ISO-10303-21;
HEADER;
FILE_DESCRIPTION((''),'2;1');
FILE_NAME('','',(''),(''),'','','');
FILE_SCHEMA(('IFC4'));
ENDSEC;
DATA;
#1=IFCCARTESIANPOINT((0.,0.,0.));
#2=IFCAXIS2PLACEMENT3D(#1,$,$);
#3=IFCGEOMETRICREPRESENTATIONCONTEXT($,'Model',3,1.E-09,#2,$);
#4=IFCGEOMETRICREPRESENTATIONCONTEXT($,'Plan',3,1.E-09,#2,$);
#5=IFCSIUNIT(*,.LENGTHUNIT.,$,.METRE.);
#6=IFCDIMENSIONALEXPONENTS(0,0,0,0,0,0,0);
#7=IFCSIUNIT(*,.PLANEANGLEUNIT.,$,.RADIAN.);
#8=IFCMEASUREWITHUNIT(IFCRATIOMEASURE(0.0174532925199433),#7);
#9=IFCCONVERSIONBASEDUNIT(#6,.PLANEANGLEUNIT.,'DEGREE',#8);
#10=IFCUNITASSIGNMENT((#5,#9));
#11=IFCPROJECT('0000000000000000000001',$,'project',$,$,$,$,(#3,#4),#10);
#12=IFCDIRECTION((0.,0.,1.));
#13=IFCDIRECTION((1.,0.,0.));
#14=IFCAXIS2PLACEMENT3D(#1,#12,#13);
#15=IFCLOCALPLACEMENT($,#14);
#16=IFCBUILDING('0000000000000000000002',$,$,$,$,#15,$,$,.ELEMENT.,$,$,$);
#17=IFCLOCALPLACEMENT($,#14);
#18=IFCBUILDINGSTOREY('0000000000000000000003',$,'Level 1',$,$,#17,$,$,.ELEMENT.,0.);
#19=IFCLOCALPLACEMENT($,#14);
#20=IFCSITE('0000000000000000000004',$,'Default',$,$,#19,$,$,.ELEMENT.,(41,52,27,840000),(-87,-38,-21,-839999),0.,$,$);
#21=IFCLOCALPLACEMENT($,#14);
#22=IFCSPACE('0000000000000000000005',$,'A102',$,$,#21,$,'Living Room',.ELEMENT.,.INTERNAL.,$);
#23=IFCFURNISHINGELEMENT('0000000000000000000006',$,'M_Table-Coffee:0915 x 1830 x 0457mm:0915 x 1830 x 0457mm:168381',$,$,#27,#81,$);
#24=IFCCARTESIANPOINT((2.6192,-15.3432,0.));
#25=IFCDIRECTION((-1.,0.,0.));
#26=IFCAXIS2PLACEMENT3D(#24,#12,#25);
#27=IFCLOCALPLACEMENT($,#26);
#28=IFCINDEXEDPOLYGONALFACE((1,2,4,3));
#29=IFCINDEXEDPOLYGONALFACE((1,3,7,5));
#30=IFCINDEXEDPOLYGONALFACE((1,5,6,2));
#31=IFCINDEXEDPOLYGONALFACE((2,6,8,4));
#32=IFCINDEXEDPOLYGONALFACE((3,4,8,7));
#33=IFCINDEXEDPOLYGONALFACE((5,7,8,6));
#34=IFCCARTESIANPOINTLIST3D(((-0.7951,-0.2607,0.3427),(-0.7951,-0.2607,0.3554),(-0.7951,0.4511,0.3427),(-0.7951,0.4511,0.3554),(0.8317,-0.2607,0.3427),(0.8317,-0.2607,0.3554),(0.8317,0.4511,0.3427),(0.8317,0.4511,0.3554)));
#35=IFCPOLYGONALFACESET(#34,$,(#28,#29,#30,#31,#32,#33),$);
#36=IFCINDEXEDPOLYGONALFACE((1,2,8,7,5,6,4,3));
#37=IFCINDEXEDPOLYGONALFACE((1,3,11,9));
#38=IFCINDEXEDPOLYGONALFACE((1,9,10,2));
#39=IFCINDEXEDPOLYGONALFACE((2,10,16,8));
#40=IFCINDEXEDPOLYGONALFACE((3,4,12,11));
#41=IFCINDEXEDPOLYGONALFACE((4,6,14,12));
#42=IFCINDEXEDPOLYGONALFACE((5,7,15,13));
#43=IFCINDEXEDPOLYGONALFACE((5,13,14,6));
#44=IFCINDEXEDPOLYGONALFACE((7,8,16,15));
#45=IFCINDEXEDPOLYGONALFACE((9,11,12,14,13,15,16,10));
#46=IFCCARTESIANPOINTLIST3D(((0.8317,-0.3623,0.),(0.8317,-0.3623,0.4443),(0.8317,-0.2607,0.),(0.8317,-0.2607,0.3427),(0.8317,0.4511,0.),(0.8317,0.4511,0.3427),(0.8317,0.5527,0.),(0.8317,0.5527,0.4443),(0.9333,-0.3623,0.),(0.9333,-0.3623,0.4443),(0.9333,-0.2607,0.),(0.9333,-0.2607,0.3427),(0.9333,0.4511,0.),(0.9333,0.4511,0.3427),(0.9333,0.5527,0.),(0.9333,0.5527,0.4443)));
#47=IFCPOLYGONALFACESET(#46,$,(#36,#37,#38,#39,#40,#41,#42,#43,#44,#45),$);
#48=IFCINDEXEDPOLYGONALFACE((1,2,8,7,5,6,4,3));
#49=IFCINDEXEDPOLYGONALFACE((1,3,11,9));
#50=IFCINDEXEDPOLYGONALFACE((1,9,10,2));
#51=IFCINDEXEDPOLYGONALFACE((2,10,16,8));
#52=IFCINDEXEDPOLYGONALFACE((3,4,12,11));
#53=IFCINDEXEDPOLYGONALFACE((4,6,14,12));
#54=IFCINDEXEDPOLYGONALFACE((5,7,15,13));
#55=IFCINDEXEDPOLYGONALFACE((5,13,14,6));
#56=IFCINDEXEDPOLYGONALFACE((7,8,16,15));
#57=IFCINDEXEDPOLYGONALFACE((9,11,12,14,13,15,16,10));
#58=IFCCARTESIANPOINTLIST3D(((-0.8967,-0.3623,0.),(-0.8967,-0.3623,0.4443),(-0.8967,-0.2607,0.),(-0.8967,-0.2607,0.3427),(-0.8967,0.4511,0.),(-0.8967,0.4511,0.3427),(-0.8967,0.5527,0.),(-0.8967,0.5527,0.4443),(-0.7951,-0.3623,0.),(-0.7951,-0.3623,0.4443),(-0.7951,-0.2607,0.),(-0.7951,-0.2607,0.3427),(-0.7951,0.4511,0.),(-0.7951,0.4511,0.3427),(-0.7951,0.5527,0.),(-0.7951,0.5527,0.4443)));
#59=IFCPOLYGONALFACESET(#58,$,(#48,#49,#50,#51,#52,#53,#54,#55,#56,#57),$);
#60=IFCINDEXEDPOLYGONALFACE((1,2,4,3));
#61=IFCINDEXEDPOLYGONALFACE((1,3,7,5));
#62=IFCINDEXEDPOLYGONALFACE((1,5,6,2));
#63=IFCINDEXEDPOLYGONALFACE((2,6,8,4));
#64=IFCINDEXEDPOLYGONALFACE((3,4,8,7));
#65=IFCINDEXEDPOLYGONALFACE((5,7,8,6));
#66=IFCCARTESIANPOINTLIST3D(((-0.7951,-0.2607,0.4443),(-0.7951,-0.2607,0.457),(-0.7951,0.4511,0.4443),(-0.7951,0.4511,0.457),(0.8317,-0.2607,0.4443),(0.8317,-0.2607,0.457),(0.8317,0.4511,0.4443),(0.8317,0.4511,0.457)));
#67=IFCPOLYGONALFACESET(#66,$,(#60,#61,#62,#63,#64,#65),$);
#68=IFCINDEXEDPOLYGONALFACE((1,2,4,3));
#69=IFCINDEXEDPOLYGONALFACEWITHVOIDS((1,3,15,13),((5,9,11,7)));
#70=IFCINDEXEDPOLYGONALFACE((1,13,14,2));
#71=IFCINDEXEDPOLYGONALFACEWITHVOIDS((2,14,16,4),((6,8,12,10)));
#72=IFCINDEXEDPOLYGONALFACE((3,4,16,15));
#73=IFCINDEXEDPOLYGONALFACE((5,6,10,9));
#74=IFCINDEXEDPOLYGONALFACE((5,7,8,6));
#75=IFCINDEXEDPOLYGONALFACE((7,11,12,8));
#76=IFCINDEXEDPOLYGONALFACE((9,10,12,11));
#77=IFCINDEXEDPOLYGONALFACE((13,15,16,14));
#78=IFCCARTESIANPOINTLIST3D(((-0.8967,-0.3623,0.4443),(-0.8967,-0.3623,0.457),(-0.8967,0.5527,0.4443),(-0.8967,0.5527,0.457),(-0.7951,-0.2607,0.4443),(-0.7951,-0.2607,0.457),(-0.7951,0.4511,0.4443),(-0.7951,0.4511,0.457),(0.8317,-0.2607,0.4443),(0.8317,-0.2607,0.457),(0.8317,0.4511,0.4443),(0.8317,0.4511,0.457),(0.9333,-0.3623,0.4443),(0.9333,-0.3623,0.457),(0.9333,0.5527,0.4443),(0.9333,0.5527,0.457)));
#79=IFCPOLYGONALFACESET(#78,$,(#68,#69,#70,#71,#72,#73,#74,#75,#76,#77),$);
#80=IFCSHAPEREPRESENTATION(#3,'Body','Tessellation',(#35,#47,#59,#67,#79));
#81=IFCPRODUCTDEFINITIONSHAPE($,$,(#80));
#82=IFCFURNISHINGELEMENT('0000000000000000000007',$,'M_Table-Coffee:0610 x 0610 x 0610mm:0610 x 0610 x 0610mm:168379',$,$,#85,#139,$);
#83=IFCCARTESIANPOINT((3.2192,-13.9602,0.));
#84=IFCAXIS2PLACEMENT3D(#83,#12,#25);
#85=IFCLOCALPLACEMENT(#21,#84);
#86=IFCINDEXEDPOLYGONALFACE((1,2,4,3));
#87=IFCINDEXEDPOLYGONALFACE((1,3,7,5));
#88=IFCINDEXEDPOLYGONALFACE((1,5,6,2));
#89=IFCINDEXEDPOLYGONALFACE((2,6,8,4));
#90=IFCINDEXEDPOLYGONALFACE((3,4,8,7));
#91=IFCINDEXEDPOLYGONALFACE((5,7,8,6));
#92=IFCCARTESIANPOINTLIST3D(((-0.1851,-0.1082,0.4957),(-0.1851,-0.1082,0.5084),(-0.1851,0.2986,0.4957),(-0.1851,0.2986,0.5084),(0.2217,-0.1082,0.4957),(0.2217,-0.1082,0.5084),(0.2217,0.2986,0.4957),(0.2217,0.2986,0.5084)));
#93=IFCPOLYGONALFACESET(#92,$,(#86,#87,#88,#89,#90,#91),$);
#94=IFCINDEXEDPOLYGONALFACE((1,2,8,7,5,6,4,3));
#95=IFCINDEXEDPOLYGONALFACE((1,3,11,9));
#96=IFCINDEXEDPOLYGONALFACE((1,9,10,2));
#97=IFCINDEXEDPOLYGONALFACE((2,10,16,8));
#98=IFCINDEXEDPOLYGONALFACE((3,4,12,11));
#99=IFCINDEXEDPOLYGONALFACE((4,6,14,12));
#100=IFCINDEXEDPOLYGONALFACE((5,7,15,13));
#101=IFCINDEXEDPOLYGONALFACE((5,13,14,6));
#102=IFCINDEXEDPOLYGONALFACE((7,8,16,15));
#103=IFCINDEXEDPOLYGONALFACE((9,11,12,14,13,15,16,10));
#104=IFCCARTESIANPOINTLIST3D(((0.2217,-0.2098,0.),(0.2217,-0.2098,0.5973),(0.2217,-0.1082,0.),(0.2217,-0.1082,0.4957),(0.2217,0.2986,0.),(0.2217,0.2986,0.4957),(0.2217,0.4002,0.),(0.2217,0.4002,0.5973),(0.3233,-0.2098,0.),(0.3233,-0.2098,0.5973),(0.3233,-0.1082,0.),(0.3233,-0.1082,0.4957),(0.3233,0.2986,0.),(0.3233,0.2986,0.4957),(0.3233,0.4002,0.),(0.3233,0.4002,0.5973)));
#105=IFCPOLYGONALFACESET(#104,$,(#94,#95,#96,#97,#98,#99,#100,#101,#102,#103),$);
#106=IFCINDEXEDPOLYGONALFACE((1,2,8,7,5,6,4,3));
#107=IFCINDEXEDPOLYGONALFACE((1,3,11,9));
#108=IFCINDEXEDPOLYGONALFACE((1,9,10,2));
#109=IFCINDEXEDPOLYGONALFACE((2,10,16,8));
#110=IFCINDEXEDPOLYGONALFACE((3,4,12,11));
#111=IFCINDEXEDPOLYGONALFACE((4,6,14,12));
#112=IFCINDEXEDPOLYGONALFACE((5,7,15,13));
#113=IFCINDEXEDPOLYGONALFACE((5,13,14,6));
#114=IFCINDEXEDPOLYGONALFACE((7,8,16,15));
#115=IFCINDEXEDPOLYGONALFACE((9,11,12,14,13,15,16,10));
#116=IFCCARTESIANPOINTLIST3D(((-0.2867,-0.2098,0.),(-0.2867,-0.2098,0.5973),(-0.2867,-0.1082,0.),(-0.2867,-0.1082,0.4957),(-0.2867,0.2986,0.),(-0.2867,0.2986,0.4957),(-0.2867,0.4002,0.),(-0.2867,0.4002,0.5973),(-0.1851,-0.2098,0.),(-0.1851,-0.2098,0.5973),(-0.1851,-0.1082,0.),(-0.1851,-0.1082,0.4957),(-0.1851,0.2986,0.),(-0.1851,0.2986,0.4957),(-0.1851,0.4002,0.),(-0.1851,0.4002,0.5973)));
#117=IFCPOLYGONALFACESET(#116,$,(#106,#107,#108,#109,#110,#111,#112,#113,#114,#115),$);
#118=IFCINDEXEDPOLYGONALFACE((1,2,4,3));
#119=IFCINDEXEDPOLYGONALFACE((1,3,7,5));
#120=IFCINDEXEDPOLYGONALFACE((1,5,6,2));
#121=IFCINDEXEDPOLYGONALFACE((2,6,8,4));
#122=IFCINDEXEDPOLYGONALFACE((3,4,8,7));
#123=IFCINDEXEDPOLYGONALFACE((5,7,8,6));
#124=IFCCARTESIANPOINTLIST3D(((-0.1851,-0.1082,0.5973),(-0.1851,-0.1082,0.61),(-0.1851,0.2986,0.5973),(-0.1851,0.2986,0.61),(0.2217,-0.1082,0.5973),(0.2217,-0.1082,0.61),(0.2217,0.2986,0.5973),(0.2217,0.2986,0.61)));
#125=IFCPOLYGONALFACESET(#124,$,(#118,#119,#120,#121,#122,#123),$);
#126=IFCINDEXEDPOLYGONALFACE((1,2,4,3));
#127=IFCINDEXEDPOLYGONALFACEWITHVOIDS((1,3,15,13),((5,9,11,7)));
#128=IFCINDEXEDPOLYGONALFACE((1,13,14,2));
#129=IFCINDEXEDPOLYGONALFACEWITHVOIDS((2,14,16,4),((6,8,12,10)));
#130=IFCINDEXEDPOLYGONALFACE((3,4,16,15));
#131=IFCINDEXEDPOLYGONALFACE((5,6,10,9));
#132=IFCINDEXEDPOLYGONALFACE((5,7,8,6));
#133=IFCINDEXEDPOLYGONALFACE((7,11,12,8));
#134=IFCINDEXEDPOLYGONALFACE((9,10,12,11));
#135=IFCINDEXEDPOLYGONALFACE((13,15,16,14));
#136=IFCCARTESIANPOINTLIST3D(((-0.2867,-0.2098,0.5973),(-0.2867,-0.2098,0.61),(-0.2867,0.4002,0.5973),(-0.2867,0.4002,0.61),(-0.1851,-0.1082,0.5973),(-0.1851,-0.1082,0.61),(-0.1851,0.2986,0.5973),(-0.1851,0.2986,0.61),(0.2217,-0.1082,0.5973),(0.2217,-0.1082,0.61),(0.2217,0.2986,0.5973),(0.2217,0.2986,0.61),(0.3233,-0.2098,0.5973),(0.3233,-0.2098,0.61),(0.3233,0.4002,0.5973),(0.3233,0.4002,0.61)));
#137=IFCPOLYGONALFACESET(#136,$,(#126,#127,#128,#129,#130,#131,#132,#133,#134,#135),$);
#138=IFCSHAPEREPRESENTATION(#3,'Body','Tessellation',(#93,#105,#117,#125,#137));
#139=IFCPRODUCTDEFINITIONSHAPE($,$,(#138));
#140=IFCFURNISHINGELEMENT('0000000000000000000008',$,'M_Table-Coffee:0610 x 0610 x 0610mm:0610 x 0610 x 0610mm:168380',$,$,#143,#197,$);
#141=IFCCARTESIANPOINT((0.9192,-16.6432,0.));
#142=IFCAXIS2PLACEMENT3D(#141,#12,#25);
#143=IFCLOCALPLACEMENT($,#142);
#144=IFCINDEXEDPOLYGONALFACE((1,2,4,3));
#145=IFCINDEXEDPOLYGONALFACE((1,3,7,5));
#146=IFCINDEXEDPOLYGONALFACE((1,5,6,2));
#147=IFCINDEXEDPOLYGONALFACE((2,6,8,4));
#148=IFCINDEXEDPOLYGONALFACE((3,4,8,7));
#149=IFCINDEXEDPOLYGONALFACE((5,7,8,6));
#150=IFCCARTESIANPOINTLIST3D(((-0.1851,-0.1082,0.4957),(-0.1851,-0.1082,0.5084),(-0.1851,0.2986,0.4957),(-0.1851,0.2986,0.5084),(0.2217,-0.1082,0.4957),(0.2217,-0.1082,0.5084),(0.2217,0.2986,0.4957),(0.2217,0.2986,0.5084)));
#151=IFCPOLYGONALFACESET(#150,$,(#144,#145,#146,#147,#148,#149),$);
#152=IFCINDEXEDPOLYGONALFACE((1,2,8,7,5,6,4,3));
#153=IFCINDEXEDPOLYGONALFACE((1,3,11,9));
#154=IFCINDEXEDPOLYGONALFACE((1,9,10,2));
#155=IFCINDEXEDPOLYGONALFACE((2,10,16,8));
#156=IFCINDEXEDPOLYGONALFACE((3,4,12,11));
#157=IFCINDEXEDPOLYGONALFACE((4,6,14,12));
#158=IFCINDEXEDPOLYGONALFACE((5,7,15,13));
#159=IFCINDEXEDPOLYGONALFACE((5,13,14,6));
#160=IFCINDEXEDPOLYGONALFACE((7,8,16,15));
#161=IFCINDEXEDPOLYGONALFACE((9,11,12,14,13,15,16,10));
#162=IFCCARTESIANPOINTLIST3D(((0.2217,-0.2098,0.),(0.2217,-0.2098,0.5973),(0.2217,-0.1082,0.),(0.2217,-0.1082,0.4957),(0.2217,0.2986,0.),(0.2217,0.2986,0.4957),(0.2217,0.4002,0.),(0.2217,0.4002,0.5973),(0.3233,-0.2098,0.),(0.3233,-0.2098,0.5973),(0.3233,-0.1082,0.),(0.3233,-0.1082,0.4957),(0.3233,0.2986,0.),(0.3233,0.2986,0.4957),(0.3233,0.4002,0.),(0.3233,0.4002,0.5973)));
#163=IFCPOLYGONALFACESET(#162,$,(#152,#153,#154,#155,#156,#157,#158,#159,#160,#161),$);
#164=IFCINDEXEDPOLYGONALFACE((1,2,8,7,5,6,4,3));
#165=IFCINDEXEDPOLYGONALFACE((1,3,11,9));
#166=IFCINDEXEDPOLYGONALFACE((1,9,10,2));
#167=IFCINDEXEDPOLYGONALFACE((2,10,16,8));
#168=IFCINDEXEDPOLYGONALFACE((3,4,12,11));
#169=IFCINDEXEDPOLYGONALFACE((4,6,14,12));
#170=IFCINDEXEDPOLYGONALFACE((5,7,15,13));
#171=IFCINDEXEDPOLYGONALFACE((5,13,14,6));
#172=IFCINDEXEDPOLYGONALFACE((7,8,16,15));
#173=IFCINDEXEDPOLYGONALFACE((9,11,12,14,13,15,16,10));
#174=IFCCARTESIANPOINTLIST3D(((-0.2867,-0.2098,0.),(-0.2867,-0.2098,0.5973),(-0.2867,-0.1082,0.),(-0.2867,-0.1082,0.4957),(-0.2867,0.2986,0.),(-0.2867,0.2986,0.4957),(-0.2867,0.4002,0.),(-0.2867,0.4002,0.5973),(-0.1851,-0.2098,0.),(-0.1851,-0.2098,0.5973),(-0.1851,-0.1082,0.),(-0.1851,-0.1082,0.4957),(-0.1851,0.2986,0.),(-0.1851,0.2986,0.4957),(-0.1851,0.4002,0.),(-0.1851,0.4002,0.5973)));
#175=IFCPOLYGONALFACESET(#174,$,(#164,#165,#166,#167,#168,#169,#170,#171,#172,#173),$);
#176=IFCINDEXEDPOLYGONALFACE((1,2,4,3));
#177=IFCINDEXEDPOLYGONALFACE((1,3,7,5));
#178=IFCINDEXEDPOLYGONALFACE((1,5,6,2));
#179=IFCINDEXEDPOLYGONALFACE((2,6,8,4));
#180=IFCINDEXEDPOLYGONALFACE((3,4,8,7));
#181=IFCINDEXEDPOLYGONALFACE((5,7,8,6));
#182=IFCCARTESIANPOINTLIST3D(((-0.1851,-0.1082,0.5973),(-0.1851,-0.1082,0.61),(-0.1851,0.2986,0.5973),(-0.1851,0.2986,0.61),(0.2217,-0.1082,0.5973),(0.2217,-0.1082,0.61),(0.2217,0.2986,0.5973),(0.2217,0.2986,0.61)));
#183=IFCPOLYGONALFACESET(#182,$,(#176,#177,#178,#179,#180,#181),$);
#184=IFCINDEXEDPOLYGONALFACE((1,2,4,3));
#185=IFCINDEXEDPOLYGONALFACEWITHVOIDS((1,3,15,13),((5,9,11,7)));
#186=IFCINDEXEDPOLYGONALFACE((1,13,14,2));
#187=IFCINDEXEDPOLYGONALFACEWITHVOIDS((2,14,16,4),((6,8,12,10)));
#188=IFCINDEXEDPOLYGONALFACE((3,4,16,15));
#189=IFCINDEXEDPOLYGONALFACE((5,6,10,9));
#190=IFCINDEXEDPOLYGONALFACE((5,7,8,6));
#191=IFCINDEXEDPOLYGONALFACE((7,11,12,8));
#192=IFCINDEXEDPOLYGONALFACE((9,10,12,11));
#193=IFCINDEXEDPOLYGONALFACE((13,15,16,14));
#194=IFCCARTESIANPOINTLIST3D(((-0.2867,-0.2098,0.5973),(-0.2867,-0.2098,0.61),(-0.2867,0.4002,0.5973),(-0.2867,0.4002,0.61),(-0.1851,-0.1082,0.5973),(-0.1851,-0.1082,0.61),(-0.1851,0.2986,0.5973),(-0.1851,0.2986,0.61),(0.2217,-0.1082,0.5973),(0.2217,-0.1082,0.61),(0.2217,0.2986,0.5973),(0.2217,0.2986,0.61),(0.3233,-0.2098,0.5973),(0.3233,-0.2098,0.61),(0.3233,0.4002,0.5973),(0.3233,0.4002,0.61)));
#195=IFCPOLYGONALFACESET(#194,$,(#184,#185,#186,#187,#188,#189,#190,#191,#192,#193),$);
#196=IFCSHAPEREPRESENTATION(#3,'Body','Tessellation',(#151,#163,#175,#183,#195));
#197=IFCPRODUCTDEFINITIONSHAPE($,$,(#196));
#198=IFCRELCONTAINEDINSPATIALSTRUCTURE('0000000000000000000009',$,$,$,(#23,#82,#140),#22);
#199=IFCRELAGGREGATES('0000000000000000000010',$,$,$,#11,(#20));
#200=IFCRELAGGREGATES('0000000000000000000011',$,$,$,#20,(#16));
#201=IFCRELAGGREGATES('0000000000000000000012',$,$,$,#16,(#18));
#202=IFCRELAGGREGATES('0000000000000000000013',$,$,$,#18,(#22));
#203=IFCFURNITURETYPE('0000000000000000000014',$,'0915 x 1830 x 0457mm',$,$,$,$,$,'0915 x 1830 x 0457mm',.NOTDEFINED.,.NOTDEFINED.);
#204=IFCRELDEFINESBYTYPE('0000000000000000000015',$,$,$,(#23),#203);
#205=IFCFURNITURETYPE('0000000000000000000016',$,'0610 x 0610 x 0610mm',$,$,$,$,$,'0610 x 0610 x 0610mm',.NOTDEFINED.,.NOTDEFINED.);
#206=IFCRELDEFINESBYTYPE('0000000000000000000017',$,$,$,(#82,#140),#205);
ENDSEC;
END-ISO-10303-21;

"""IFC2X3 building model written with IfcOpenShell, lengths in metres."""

from ifc_helpers import new_model, entity, si_unit, converted_unit, frame, origin, origin_with_axes, origin_2d_with_axis, place, context, project, spatial, polyline, rectangle, outline, extrude, source, transform, mapped, type_object, type_shapes, element, save


model = new_model("IFC2X3")

# Units and contexts
model_context = context("Model", 3, precision=1e-09, world=origin())
plan_context = context("Plan", 3, precision=1e-09, world=origin())
ifc_project = project(units=[si_unit("LENGTHUNIT", "METRE"), converted_unit("PLANEANGLEUNIT", "DEGREE", entity("IfcRatioMeasure", 0.0174532925199433), si_unit("PLANEANGLEUNIT", "RADIAN"), dimensions=[0, 0, 0, 0, 0, 0, 0])], contexts=[model_context, plan_context])

# Site, building, storey, space
site_placement = place(None, origin_with_axes())
site = spatial("IfcSite", under=ifc_project, at=site_placement, Name="Default", CompositionType="ELEMENT", RefLatitude=(41, 52, 27, 840000), RefLongitude=(-87, -38, -21, -839999), RefElevation=0.0)
building_placement = place(None, origin_with_axes())
building = spatial("IfcBuilding", under=site, at=building_placement, CompositionType="ELEMENT")
storey_placement = place(None, origin_with_axes())
storey = spatial("IfcBuildingStorey", under=building, at=storey_placement, Name="Level 1", CompositionType="ELEMENT", Elevation=0.0)
space_placement = place(None, origin_with_axes())
space = spatial("IfcSpace", under=storey, at=space_placement, Name="A102", LongName="Living Room", CompositionType="ELEMENT", InteriorOrExteriorSpace="INTERNAL")

# Furnishing elements
furniture_type_1 = type_object("IfcFurnitureType", Name="0915 x 1830 x 0457mm", ElementType="0915 x 1830 x 0457mm", AssemblyPlace="NOTDEFINED")
shared_shape_1 = source(origin(), model_context, "Body", "SweptSolid", [
    extrude(rectangle(XDim=1.6268, YDim=0.7118, at=origin_2d_with_axis()), frame((0.0183, 0.0952, 0.3427), z_axis=(0.0, 0.0, 1.0), x_axis=(-1.0, 0.0, 0.0)), (0.0, 0.0, 1.0), 0.0127),
    extrude(outline(polyline([(-0.1967, -0.4575), (0.2475, -0.4575), (0.2475, 0.4575), (-0.1967, 0.4575), (-0.1967, 0.3559), (0.146, 0.3559), (0.146, -0.3559), (-0.1967, -0.3559), (-0.1967, -0.4575)])), frame((0.8317, 0.0952, 0.1967), z_axis=(1.0, 0.0, 0.0), x_axis=(0.0, 0.0, 1.0)), (0.0, 0.0, 1.0), 0.1016),
    extrude(outline(polyline([(-0.4575, -0.2476), (0.4575, -0.2476), (0.4575, 0.1968), (0.3559, 0.1968), (0.3559, -0.1459), (-0.3559, -0.1459), (-0.3559, 0.1968), (-0.4575, 0.1968), (-0.4575, -0.2476)])), frame((-0.8967, 0.0952, 0.1968), z_axis=(1.0, 0.0, 0.0), x_axis=(0.0, -1.0, 0.0)), (0.0, 0.0, 1.0), 0.1016),
    extrude(rectangle(XDim=1.6268, YDim=0.7118, at=origin_2d_with_axis()), frame((0.0183, 0.0952, 0.4443), z_axis=(0.0, 0.0, 1.0), x_axis=(-1.0, 0.0, 0.0)), (0.0, 0.0, 1.0), 0.0127),
    extrude(outline(polyline([(-0.915, -0.4575), (0.915, -0.4575), (0.915, 0.4575), (-0.915, 0.4575), (-0.915, -0.4575)]), holes=[polyline([(-0.8134, -0.3559), (-0.8134, 0.3559), (0.8134, 0.3559), (0.8134, -0.3559), (-0.8134, -0.3559)])]), frame((0.0183, 0.0952, 0.4443), z_axis=(0.0, 0.0, 1.0), x_axis=(-1.0, 0.0, 0.0)), (0.0, 0.0, 1.0), 0.0127),
])
type_shapes(furniture_type_1, [shared_shape_1])
furnishing_1_placement = place(None, frame((2.6192, -15.3432, 0.0), z_axis=(0.0, 0.0, 1.0), x_axis=(-1.0, 0.0, 0.0)))
element("IfcFurnishingElement", 1, at=furnishing_1_placement, inside=space, type_object=furniture_type_1, Name="M_Table-Coffee:0915 x 1830 x 0457mm:0915 x 1830 x 0457mm:168381", context=model_context, shape_type="MappedRepresentation", body=[
    mapped(shared_shape_1, transform((0.0, 0.0, 0.0), scale=1.0)),
])
furniture_type_2 = type_object("IfcFurnitureType", Name="0610 x 0610 x 0610mm", ElementType="0610 x 0610 x 0610mm", AssemblyPlace="NOTDEFINED")
shared_shape_2 = source(origin(), model_context, "Body", "SweptSolid", [
    extrude(rectangle(XDim=0.4068, YDim=0.4068, at=origin_2d_with_axis()), frame((0.0183, 0.0952, 0.4957), z_axis=(0.0, 0.0, 1.0), x_axis=(-1.0, 0.0, 0.0)), (0.0, 0.0, 1.0), 0.0127),
    extrude(outline(polyline([(-0.2732, -0.305), (0.324, -0.305), (0.324, 0.305), (-0.2732, 0.305), (-0.2732, 0.2034), (0.2225, 0.2034), (0.2225, -0.2034), (-0.2732, -0.2034), (-0.2732, -0.305)])), frame((0.2217, 0.0952, 0.2732), z_axis=(1.0, 0.0, 0.0), x_axis=(0.0, 0.0, 1.0)), (0.0, 0.0, 1.0), 0.1016),
    extrude(outline(polyline([(-0.305, -0.3241), (0.305, -0.3241), (0.305, 0.2733), (0.2034, 0.2733), (0.2034, -0.2224), (-0.2034, -0.2224), (-0.2034, 0.2733), (-0.305, 0.2733), (-0.305, -0.3241)])), frame((-0.2867, 0.0952, 0.2733), z_axis=(1.0, 0.0, 0.0), x_axis=(0.0, -1.0, 0.0)), (0.0, 0.0, 1.0), 0.1016),
    extrude(rectangle(XDim=0.4068, YDim=0.4068, at=origin_2d_with_axis()), frame((0.0183, 0.0952, 0.5973), z_axis=(0.0, 0.0, 1.0), x_axis=(-1.0, 0.0, 0.0)), (0.0, 0.0, 1.0), 0.0127),
    extrude(outline(polyline([(-0.305, -0.305), (0.305, -0.305), (0.305, 0.305), (-0.305, 0.305), (-0.305, -0.305)]), holes=[polyline([(-0.2034, -0.2034), (-0.2034, 0.2034), (0.2034, 0.2034), (0.2034, -0.2034), (-0.2034, -0.2034)])]), frame((0.0183, 0.0952, 0.5973), z_axis=(0.0, 0.0, 1.0), x_axis=(-1.0, 0.0, 0.0)), (0.0, 0.0, 1.0), 0.0127),
])
type_shapes(furniture_type_2, [shared_shape_2])
furnishing_2_placement = place(space_placement, frame((3.2192, -13.9602, 0.0), z_axis=(0.0, 0.0, 1.0), x_axis=(-1.0, 0.0, 0.0)))
element("IfcFurnishingElement", 2, at=furnishing_2_placement, inside=space, type_object=furniture_type_2, Name="M_Table-Coffee:0610 x 0610 x 0610mm:0610 x 0610 x 0610mm:168379", context=model_context, shape_type="MappedRepresentation", body=[
    mapped(shared_shape_2, transform((0.0, 0.0, 0.0), scale=1.0)),
])
furnishing_3_placement = place(None, frame((0.9192, -16.6432, 0.0), z_axis=(0.0, 0.0, 1.0), x_axis=(-1.0, 0.0, 0.0)))
element("IfcFurnishingElement", 3, at=furnishing_3_placement, inside=space, type_object=furniture_type_2, Name="M_Table-Coffee:0610 x 0610 x 0610mm:0610 x 0610 x 0610mm:168380", context=model_context, shape_type="MappedRepresentation", body=[
    mapped(shared_shape_2, transform((0.0, 0.0, 0.0), scale=1.0)),
])

save(model, "model.ifc")
